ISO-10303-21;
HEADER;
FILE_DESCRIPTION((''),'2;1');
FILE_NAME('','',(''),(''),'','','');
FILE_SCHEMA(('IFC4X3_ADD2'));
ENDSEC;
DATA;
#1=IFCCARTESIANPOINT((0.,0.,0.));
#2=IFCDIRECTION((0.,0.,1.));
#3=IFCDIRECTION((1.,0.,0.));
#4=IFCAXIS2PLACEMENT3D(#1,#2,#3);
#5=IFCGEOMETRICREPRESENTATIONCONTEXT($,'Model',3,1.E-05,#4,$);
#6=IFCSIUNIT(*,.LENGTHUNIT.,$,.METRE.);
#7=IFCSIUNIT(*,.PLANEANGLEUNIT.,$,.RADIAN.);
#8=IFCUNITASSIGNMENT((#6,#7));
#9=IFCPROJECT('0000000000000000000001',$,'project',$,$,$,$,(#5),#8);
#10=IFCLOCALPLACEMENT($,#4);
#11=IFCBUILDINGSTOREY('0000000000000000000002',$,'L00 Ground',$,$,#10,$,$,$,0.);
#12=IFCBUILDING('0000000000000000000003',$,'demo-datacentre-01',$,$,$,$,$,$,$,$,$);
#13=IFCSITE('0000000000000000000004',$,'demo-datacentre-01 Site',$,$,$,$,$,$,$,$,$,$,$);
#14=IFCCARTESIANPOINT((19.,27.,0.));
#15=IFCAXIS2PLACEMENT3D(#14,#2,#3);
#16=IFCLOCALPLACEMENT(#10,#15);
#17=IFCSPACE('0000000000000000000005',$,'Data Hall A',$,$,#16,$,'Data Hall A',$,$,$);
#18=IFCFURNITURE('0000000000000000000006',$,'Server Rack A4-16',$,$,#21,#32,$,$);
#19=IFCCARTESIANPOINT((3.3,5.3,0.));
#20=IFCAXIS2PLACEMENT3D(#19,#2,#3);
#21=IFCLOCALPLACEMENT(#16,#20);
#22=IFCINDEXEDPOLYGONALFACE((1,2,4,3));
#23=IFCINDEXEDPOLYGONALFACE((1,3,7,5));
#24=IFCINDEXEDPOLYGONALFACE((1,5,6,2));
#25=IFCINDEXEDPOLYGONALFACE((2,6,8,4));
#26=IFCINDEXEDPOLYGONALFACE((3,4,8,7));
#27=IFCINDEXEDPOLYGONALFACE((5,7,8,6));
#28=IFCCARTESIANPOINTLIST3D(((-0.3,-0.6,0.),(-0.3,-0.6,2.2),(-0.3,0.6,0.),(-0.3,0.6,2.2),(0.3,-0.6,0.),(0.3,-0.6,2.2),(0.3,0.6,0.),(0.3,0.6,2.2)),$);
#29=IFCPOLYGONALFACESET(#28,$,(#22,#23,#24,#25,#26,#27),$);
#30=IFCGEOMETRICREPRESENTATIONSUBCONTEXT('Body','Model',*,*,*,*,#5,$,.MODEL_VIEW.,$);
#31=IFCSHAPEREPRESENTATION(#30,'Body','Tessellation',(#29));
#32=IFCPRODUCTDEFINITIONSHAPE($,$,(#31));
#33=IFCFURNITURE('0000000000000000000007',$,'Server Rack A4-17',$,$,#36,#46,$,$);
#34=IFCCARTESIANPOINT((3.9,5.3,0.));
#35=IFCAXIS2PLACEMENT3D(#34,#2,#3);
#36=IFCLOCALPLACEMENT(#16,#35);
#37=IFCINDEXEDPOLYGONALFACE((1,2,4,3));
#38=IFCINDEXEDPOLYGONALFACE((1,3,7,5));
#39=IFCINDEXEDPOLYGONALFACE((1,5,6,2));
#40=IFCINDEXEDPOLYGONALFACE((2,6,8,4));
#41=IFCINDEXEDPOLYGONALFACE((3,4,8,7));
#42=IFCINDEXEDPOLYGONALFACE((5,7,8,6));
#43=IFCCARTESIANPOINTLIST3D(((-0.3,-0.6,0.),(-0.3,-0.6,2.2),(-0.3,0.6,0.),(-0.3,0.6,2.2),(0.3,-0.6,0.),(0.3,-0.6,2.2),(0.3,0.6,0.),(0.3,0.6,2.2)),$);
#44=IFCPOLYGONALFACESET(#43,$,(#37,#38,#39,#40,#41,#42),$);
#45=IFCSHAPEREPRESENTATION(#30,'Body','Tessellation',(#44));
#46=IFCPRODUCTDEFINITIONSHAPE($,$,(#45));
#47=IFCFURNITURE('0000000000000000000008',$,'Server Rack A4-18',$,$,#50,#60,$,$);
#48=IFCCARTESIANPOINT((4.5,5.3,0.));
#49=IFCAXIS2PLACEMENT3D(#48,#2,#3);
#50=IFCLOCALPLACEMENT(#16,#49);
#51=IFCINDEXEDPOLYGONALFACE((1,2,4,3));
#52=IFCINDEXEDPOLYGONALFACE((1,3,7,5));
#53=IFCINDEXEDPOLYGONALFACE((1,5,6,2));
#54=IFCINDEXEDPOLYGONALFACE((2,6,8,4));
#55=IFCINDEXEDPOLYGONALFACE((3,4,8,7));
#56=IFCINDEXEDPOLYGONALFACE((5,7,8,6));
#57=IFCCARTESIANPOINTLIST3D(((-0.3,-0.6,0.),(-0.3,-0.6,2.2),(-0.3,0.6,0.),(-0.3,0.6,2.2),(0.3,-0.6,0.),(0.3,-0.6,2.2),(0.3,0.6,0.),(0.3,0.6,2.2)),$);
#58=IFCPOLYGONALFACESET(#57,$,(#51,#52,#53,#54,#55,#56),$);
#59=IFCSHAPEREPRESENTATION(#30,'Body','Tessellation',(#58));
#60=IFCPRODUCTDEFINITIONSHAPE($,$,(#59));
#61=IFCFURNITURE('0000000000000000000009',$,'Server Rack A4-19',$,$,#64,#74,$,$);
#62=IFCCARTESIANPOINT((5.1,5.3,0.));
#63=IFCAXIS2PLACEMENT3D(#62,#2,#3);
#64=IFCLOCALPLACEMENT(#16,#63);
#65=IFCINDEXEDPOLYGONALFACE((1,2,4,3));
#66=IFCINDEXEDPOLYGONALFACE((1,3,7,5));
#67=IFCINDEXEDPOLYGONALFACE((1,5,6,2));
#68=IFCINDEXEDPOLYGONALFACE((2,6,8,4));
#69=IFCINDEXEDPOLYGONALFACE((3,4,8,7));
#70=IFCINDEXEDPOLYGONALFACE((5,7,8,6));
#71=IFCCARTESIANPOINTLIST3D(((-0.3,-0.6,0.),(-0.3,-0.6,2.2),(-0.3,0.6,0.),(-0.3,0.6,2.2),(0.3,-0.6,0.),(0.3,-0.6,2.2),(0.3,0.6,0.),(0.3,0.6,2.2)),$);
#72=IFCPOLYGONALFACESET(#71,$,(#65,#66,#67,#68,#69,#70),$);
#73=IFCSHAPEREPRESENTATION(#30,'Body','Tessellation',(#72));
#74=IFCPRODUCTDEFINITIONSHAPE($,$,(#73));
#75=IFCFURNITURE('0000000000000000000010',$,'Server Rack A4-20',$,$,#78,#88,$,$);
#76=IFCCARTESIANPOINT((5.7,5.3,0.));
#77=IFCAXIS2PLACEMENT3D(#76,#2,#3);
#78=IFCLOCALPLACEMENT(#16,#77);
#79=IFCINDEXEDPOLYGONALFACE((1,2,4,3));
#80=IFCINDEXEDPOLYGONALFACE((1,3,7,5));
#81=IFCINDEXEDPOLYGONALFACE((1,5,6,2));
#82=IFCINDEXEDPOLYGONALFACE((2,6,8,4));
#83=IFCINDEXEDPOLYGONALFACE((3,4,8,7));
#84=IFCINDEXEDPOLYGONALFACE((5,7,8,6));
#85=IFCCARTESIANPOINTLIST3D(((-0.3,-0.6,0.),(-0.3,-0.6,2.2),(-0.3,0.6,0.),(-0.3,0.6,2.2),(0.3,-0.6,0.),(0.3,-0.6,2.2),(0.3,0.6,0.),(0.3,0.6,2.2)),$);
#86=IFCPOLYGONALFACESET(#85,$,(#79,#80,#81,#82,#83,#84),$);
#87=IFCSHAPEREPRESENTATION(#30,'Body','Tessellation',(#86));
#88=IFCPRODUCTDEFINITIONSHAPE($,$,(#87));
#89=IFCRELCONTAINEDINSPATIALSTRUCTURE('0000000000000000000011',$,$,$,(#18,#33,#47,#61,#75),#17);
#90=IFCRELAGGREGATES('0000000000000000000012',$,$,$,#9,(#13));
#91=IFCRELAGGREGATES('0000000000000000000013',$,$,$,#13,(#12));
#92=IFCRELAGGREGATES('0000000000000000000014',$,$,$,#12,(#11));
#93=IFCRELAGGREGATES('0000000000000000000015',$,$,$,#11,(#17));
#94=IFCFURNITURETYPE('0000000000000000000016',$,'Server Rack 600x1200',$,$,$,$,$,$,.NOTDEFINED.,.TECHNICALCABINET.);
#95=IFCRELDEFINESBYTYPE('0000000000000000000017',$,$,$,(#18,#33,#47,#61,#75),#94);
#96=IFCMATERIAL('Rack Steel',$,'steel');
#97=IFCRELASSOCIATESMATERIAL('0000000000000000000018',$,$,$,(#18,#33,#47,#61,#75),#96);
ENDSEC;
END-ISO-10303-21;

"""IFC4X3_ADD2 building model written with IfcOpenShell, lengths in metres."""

from ifc_helpers import new_model, si_unit, frame, origin_with_axes, place, context, subcontext, project, spatial, rectangle, extrude, material, type_object, element, save


model = new_model("IFC4X3_ADD2")

# Units and contexts
model_context = context("Model", 3, precision=1e-05, world=origin_with_axes())
body_context = subcontext(model_context, "Body", "Model", "MODEL_VIEW")
ifc_project = project(units=[si_unit("LENGTHUNIT", "METRE"), si_unit("PLANEANGLEUNIT", "RADIAN")], contexts=[model_context])

# Site, building, storey
site = spatial("IfcSite", under=ifc_project, Name="demo-datacentre-01 Site")
building = spatial("IfcBuilding", under=site, Name="demo-datacentre-01")
storey_placement = place(None, origin_with_axes())
storey = spatial("IfcBuildingStorey", under=building, at=storey_placement, Name="L00 Ground", Elevation=0.0)

# Shared definitions
space_placement = place(storey_placement, frame((19.0, 27.0, 0.0), z_axis=(0.0, 0.0, 1.0), x_axis=(1.0, 0.0, 0.0)))
space = spatial("IfcSpace", under=storey, at=space_placement, Name="Data Hall A", LongName="Data Hall A")

# Furniture
ifc_material_1 = material(Name="Rack Steel", Category="steel")
furniture_type = type_object("IfcFurnitureType", Name="Server Rack 600x1200", AssemblyPlace="NOTDEFINED", PredefinedType="TECHNICALCABINET")
for number, where, z_axis, x_axis, name in (
    (1, (3.3, 5.3, 0.0), (0.0, 0.0, 1.0), (1.0, 0.0, 0.0), "Server Rack A4-16"),
    (2, (3.9, 5.3, 0.0), (0.0, 0.0, 1.0), (1.0, 0.0, 0.0), "Server Rack A4-17"),
    (3, (4.5, 5.3, 0.0), (0.0, 0.0, 1.0), (1.0, 0.0, 0.0), "Server Rack A4-18"),
    (4, (5.1, 5.3, 0.0), (0.0, 0.0, 1.0), (1.0, 0.0, 0.0), "Server Rack A4-19"),
    (5, (5.7, 5.3, 0.0), (0.0, 0.0, 1.0), (1.0, 0.0, 0.0), "Server Rack A4-20"),
):
    element("IfcFurniture", number, at=place(space_placement, frame(where, z_axis=z_axis, x_axis=x_axis)), inside=space, type_object=furniture_type, material=ifc_material_1, Name=name, context=body_context, shape_type="SweptSolid", body=[
        extrude(rectangle(XDim=0.6, YDim=1.2), origin_with_axes(), (0.0, 0.0, 1.0), 2.2),
    ])

save(model, "model.ifc")
